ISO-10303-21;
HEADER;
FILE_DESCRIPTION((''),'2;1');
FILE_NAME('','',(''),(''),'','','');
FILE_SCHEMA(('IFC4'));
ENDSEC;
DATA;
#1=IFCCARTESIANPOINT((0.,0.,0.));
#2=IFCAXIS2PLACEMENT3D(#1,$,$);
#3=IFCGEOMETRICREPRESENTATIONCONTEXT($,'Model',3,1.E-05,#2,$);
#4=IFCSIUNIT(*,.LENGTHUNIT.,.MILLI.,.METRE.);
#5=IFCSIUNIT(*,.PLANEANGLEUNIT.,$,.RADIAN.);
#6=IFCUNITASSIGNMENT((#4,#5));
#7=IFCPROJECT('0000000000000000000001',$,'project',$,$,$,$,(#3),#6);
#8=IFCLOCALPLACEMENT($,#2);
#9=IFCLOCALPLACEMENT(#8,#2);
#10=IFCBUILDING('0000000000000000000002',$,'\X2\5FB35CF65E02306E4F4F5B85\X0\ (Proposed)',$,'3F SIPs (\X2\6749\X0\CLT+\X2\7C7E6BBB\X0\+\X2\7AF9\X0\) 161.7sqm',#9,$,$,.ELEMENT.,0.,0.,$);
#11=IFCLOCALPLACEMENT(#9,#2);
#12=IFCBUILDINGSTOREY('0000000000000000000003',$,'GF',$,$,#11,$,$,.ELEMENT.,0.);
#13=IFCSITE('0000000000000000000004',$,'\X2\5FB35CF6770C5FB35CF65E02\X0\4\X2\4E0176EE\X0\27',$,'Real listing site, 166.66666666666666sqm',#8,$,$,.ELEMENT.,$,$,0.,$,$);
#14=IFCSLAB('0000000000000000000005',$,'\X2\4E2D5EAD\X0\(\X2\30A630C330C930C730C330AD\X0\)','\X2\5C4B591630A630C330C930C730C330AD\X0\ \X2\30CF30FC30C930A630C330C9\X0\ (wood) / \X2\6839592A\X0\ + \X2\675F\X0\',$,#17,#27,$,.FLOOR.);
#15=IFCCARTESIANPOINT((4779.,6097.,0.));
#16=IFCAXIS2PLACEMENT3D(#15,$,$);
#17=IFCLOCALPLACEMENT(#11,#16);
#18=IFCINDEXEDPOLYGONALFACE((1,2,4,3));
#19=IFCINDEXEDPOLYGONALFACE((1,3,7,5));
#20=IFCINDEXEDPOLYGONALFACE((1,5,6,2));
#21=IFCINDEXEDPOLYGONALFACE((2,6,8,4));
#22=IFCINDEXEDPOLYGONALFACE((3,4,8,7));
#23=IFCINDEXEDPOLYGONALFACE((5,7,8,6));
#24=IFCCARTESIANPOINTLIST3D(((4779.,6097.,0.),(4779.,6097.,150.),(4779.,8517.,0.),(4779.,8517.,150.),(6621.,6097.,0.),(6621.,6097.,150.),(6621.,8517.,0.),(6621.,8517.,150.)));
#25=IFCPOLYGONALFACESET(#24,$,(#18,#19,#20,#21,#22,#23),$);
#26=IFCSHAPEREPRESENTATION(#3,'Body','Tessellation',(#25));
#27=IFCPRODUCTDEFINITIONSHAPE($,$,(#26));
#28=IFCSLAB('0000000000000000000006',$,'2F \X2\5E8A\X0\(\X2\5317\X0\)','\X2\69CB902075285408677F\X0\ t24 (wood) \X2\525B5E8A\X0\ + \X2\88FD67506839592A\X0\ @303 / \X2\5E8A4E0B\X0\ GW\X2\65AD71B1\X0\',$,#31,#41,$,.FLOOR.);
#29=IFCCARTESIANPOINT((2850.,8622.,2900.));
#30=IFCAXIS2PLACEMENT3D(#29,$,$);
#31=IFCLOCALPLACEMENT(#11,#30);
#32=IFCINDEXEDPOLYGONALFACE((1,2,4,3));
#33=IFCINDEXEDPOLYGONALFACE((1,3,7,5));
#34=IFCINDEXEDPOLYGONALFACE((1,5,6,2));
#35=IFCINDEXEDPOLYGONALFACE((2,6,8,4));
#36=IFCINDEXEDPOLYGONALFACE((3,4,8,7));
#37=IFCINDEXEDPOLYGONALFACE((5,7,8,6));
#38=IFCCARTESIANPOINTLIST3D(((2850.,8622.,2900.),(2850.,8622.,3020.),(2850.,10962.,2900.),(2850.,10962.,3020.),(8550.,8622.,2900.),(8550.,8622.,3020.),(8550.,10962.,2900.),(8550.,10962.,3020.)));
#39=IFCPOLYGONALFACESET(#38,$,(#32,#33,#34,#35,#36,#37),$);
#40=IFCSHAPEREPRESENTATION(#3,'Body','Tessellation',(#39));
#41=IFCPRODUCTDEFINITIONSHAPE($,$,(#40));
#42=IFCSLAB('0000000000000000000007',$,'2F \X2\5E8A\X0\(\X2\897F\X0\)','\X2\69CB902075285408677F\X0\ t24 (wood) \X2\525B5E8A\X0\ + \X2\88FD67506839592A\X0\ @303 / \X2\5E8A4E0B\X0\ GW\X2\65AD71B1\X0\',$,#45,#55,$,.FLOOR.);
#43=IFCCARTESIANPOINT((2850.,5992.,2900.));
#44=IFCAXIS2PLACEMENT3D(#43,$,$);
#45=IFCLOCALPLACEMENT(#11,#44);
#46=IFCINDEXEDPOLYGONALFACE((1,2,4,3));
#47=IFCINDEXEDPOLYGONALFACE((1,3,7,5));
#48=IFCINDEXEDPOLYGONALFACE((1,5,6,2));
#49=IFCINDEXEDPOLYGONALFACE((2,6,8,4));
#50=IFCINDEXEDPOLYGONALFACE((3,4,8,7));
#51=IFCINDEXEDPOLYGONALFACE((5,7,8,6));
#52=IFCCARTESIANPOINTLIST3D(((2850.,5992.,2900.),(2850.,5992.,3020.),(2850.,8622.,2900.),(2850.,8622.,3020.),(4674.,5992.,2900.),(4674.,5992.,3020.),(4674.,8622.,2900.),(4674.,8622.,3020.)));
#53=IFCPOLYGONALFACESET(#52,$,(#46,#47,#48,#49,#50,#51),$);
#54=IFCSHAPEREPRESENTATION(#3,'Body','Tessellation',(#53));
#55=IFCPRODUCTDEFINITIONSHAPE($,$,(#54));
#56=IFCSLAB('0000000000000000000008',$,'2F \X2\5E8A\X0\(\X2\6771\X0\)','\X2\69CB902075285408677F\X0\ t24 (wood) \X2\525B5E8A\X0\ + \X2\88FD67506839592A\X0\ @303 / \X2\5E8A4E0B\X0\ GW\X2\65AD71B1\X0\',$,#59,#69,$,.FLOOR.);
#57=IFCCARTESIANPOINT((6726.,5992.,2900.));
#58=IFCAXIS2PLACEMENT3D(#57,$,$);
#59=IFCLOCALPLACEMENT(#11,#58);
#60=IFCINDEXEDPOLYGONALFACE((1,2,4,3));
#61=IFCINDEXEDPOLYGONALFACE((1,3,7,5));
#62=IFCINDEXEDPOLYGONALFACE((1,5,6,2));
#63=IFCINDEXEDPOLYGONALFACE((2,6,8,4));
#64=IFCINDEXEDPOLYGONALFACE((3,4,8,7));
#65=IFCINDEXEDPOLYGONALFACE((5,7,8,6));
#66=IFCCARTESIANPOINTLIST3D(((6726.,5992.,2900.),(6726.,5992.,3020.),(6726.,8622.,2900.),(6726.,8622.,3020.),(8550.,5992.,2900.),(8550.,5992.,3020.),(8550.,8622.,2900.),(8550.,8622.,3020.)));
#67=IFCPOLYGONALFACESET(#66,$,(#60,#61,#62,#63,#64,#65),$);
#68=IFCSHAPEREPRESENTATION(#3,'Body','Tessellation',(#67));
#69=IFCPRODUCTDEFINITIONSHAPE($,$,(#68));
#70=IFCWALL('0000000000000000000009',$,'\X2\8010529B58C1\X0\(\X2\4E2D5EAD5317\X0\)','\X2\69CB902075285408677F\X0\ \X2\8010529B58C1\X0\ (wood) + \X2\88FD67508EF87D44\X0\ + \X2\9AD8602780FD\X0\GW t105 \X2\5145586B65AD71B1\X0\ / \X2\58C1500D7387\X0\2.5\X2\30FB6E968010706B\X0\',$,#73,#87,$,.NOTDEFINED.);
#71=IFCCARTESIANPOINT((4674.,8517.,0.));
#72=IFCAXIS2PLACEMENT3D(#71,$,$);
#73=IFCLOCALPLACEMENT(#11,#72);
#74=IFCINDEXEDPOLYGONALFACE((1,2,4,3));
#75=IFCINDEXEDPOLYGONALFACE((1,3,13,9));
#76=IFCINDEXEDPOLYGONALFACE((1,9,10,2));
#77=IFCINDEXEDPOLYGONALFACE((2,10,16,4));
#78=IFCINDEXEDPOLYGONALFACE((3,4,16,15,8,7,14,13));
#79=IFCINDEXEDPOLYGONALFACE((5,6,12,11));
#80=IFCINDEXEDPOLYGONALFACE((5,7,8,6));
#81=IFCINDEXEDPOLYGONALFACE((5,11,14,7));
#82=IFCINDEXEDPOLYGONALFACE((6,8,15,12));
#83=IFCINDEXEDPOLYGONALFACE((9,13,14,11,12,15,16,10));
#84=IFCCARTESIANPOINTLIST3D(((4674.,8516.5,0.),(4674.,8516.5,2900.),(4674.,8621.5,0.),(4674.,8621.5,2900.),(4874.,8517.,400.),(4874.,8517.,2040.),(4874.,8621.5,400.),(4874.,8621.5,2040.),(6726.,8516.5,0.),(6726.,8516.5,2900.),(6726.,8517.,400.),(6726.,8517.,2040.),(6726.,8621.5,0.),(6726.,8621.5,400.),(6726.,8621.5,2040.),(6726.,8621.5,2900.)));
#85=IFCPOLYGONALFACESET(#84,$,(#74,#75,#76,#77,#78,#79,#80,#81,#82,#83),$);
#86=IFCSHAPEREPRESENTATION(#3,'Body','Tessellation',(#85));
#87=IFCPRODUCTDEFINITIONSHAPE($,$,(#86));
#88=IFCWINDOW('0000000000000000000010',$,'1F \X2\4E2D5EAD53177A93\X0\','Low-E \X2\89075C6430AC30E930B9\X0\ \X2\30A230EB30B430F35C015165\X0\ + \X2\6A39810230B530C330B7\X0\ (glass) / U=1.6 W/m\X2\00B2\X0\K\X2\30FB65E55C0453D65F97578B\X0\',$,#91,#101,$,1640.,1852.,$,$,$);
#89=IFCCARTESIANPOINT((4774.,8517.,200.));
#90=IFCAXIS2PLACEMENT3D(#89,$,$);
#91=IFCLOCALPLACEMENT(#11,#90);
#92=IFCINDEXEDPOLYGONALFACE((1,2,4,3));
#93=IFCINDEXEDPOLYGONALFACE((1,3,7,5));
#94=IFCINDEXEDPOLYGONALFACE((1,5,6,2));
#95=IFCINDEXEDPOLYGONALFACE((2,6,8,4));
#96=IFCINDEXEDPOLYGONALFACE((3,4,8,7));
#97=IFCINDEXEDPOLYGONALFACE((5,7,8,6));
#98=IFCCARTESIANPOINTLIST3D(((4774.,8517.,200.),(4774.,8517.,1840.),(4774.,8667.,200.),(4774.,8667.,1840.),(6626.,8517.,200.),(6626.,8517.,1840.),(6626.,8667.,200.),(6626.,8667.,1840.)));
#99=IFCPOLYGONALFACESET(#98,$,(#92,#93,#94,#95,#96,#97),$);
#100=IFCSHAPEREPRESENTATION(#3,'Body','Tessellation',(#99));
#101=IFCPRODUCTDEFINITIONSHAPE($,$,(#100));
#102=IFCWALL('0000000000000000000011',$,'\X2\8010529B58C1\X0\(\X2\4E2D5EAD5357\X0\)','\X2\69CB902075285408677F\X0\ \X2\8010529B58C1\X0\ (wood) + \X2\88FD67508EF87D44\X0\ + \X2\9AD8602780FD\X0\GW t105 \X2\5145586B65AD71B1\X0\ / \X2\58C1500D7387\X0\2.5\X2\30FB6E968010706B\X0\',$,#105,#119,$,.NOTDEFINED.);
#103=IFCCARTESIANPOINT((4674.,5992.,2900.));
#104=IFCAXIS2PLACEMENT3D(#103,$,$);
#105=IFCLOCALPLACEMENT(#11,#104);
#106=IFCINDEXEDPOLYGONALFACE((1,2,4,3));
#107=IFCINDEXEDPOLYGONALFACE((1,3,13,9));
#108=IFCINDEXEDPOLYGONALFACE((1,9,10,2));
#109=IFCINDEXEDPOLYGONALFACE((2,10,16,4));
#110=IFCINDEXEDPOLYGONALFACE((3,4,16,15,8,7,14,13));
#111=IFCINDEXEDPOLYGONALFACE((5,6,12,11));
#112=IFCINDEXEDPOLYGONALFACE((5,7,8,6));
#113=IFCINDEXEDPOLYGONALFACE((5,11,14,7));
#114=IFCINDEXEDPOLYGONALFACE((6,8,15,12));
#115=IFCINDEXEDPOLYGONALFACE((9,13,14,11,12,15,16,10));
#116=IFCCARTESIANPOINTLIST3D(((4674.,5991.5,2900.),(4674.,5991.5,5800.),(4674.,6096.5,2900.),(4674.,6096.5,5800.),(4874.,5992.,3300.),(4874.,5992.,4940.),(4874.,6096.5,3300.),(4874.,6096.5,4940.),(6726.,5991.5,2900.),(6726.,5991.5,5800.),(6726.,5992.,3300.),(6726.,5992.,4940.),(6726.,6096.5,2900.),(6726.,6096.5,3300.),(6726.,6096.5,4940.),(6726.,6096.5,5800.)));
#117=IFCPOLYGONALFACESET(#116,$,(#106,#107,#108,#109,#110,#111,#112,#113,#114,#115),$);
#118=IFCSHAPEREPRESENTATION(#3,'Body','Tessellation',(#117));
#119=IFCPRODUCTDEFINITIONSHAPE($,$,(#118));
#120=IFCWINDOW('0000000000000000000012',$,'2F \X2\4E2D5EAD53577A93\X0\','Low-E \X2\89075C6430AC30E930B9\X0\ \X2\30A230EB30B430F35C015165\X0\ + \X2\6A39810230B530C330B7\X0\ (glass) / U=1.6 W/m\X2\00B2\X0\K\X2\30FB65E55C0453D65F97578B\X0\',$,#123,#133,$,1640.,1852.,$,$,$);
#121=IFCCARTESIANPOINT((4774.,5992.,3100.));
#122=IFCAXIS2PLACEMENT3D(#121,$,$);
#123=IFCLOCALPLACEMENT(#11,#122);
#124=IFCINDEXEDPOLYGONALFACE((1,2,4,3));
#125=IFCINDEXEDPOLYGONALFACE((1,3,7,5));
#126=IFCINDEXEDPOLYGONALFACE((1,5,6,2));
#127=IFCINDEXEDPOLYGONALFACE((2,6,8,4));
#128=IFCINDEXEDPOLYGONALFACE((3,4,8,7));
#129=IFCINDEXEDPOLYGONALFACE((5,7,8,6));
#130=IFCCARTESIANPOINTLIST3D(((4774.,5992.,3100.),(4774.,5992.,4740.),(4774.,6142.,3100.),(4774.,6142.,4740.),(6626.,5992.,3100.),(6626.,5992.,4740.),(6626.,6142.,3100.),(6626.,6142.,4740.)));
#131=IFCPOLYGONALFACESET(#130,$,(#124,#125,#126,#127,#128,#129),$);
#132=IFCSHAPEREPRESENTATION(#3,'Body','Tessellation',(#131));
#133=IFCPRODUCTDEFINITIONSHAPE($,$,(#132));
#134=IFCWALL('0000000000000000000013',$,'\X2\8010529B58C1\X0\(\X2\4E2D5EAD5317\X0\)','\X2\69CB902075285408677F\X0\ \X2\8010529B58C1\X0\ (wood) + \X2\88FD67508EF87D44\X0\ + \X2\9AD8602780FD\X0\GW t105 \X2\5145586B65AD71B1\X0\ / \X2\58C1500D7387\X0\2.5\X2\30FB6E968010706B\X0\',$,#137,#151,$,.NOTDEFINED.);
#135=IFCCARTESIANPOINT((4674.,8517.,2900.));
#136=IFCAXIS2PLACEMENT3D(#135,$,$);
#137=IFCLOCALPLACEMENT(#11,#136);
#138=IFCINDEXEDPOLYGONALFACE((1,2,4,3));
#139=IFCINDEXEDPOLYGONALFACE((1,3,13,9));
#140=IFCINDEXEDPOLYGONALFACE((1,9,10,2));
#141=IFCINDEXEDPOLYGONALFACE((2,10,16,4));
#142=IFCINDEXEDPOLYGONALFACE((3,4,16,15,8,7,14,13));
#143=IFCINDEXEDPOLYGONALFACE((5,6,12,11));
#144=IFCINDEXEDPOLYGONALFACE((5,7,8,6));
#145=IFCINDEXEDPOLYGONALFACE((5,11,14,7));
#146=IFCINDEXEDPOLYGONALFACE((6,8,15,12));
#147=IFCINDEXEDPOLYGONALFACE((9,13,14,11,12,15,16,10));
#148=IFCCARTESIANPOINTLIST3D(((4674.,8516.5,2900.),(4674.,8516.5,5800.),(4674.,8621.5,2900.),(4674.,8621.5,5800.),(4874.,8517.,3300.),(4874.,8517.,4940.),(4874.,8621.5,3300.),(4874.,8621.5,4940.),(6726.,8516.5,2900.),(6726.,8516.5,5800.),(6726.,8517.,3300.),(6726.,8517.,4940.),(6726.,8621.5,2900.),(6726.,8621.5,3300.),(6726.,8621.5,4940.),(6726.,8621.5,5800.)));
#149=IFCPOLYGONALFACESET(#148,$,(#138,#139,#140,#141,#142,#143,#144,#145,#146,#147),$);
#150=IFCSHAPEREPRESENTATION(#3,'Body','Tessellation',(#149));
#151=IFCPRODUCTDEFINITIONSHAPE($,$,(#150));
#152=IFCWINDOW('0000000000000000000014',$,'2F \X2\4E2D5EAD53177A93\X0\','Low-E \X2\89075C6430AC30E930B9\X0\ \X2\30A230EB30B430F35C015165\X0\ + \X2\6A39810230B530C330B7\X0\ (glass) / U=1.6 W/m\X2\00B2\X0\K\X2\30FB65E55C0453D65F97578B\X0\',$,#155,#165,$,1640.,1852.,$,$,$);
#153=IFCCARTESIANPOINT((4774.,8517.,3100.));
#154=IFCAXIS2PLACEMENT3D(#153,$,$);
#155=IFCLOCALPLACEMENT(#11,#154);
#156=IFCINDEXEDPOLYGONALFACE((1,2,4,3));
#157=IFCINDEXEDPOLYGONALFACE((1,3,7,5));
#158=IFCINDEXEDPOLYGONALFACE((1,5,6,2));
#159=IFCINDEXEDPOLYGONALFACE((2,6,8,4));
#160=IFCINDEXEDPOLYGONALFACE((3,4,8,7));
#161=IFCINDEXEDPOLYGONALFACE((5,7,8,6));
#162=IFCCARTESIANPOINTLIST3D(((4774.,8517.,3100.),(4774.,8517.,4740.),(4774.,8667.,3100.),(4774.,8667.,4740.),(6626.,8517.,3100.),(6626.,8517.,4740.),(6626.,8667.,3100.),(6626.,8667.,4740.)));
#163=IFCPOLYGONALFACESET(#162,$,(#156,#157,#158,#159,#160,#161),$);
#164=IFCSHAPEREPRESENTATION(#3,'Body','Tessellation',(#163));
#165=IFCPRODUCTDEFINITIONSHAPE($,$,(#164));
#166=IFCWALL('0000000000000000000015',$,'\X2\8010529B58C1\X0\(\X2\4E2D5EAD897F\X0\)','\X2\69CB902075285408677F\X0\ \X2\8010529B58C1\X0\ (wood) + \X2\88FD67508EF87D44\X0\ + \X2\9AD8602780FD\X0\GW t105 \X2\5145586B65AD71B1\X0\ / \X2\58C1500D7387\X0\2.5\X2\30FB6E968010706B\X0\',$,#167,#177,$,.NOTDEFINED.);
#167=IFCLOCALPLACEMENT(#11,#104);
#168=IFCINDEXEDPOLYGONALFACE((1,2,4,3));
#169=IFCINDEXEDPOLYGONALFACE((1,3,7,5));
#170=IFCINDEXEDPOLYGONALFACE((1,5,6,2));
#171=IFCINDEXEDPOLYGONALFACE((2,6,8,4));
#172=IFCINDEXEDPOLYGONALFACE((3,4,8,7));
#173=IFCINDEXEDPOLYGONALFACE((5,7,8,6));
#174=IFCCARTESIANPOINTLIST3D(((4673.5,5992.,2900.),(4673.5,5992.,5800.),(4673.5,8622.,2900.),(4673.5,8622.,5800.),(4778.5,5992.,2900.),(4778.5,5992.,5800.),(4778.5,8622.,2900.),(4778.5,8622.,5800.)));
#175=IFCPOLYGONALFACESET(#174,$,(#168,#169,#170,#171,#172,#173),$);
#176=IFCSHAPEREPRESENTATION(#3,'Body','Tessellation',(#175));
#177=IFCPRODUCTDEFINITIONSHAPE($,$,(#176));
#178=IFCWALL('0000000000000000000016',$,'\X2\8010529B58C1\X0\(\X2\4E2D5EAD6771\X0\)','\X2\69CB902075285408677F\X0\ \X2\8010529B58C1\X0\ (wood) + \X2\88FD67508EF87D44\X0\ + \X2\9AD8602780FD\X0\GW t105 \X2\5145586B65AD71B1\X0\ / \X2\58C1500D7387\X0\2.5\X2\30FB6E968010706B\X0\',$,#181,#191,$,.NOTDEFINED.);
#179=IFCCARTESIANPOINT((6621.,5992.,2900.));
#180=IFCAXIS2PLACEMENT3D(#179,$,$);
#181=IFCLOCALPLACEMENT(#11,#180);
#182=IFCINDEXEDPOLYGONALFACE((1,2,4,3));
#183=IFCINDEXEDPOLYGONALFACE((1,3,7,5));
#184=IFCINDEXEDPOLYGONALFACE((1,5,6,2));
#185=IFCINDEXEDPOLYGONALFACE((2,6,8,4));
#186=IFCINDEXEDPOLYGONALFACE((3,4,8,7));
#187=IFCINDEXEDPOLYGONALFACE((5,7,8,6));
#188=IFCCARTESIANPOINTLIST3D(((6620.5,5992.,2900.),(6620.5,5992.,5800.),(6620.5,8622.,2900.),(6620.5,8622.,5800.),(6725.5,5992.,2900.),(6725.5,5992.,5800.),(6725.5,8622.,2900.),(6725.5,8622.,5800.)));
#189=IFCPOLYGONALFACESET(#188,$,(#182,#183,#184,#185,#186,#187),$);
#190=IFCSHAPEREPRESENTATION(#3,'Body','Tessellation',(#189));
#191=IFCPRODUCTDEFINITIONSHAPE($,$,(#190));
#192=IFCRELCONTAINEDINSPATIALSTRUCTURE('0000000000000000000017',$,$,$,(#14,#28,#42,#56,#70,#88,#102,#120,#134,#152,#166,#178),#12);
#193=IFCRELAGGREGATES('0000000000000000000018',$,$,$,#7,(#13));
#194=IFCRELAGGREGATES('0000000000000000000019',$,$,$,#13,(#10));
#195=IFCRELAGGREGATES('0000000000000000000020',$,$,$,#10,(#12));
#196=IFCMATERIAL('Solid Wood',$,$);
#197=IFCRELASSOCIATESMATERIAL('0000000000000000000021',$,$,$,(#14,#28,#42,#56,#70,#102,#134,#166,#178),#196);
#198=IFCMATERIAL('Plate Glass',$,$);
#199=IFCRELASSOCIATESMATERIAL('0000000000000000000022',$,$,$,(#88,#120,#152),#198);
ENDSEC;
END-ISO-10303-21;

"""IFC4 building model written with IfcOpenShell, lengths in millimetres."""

from ifc_helpers import new_model, si_unit, frame, frame_2d, origin, place, context, project, spatial, rectangle, extrude, material, element, fill, save


model = new_model("IFC4")

# Units and contexts
model_context = context("Model", 3, precision=1e-05, world=origin())
ifc_project = project(units=[si_unit("LENGTHUNIT", "METRE", prefix="MILLI"), si_unit("PLANEANGLEUNIT", "RADIAN")], contexts=[model_context])

# Site, building, storey
site_placement = place(None, origin())
site = spatial("IfcSite", under=ifc_project, at=site_placement, Name="徳島県徳島市4丁目27", ObjectType="Real listing site, 166.66666666666666sqm", CompositionType="ELEMENT", RefElevation=0.0)
building_placement = place(site_placement, origin())
building = spatial("IfcBuilding", under=site, at=building_placement, Name="徳島市の住宅 (Proposed)", ObjectType="3F SIPs (杉CLT+籾殻+竹) 161.7sqm", CompositionType="ELEMENT", ElevationOfRefHeight=0.0, ElevationOfTerrain=0.0)
storey_placement = place(building_placement, origin())
storey = spatial("IfcBuildingStorey", under=building, at=storey_placement, Name="GF", CompositionType="ELEMENT", Elevation=0.0)

# Slabs
ifc_material_1 = material(Name="Solid Wood")
slab_1_placement = place(storey_placement, frame((4779.0, 6097.0, 0.0)))
element("IfcSlab", 1, at=slab_1_placement, inside=storey, material=ifc_material_1, Name="中庭(ウッドデッキ)", Description="屋外ウッドデッキ ハードウッド (wood) / 根太 + 束", PredefinedType="FLOOR", context=model_context, shape_type="SweptSolid", body=[
    extrude(rectangle(XDim=1842.0, YDim=2420.0, at=frame_2d((921.0, 1210.0))), frame((4779.0, 6097.0, 0.0)), (0.0, 0.0, 1.0), 150.0),
])
slab_2_placement = place(storey_placement, frame((2850.0, 8622.0, 2900.0)))
element("IfcSlab", 2, at=slab_2_placement, inside=storey, material=ifc_material_1, Name="2F 床(北)", Description="構造用合板 t24 (wood) 剛床 + 製材根太 @303 / 床下 GW断熱", PredefinedType="FLOOR", context=model_context, shape_type="SweptSolid", body=[
    extrude(rectangle(XDim=5700.0, YDim=2340.0, at=frame_2d((2850.0, 1170.0))), frame((2850.0, 8622.0, 2900.0)), (0.0, 0.0, 1.0), 120.0),
])
slab_3_placement = place(storey_placement, frame((2850.0, 5992.0, 2900.0)))
element("IfcSlab", 3, at=slab_3_placement, inside=storey, material=ifc_material_1, Name="2F 床(西)", Description="構造用合板 t24 (wood) 剛床 + 製材根太 @303 / 床下 GW断熱", PredefinedType="FLOOR", context=model_context, shape_type="SweptSolid", body=[
    extrude(rectangle(XDim=1824.0, YDim=2630.0, at=frame_2d((912.0, 1315.0))), frame((2850.0, 5992.0, 2900.0)), (0.0, 0.0, 1.0), 120.0),
])
slab_4_placement = place(storey_placement, frame((6726.0, 5992.0, 2900.0)))
element("IfcSlab", 4, at=slab_4_placement, inside=storey, material=ifc_material_1, Name="2F 床(東)", Description="構造用合板 t24 (wood) 剛床 + 製材根太 @303 / 床下 GW断熱", PredefinedType="FLOOR", context=model_context, shape_type="SweptSolid", body=[
    extrude(rectangle(XDim=1824.0, YDim=2630.0, at=frame_2d((912.0, 1315.0))), frame((6726.0, 5992.0, 2900.0)), (0.0, 0.0, 1.0), 120.0),
])

# Wall, opening, window
wall_1_placement = place(storey_placement, frame((4674.0, 8517.0, 0.0)))
wall_1 = element("IfcWall", 5, at=wall_1_placement, inside=storey, material=ifc_material_1, Name="耐力壁(中庭北)", Description="構造用合板 耐力壁 (wood) + 製材軸組 + 高性能GW t105 充填断熱 / 壁倍率2.5・準耐火", PredefinedType="NOTDEFINED", context=model_context, shape_type="SweptSolid", body=[
    extrude(rectangle(XDim=2052.0, YDim=105.0, at=frame_2d((1026.0, 52.0))), frame((4674.0, 8517.0, 0.0)), (0.0, 0.0, 1.0), 2900.0),
])
opening_1_placement = place(storey_placement, frame((4774.0, 8517.0, 200.0)))
opening_1 = element("IfcOpeningElement", 6, at=opening_1_placement, cuts=wall_1, PredefinedType="NOTDEFINED", context=model_context, shape_type="SweptSolid", body=[
    extrude(rectangle(XDim=1852.0, YDim=150.0, at=frame_2d((926.0, 75.0))), frame((4774.0, 8517.0, 200.0)), (0.0, 0.0, 1.0), 1640.0),
])
ifc_material_2 = material(Name="Plate Glass")
window_1_placement = place(storey_placement, frame((4774.0, 8517.0, 200.0)))
window_1 = element("IfcWindow", 7, at=window_1_placement, inside=storey, material=ifc_material_2, Name="1F 中庭北窓", Description="Low-E 複層ガラス アルゴン封入 + 樹脂サッシ (glass) / U=1.6 W/m²K・日射取得型", OverallHeight=1640.0, OverallWidth=1852.0, context=model_context, shape_type="SweptSolid", body=[
    extrude(rectangle(XDim=1852.0, YDim=150.0, at=frame_2d((926.0, 75.0))), frame((4774.0, 8517.0, 200.0)), (0.0, 0.0, 1.0), 1640.0),
])
fill(opening_1, window_1)

# Walls, openings, windows
wall_2_placement = place(storey_placement, frame((4674.0, 5992.0, 2900.0)))
wall_2 = element("IfcWall", 8, at=wall_2_placement, inside=storey, material=ifc_material_1, Name="耐力壁(中庭南)", Description="構造用合板 耐力壁 (wood) + 製材軸組 + 高性能GW t105 充填断熱 / 壁倍率2.5・準耐火", PredefinedType="NOTDEFINED", context=model_context, shape_type="SweptSolid", body=[
    extrude(rectangle(XDim=2052.0, YDim=105.0, at=frame_2d((1026.0, 52.0))), frame((4674.0, 5992.0, 2900.0)), (0.0, 0.0, 1.0), 2900.0),
])
opening_2_placement = place(storey_placement, frame((4774.0, 5992.0, 3100.0)))
opening_2 = element("IfcOpeningElement", 9, at=opening_2_placement, cuts=wall_2, PredefinedType="NOTDEFINED", context=model_context, shape_type="SweptSolid", body=[
    extrude(rectangle(XDim=1852.0, YDim=150.0, at=frame_2d((926.0, 75.0))), frame((4774.0, 5992.0, 3100.0)), (0.0, 0.0, 1.0), 1640.0),
])
window_2_placement = place(storey_placement, frame((4774.0, 5992.0, 3100.0)))
window_2 = element("IfcWindow", 10, at=window_2_placement, inside=storey, material=ifc_material_2, Name="2F 中庭南窓", Description="Low-E 複層ガラス アルゴン封入 + 樹脂サッシ (glass) / U=1.6 W/m²K・日射取得型", OverallHeight=1640.0, OverallWidth=1852.0, context=model_context, shape_type="SweptSolid", body=[
    extrude(rectangle(XDim=1852.0, YDim=150.0, at=frame_2d((926.0, 75.0))), frame((4774.0, 5992.0, 3100.0)), (0.0, 0.0, 1.0), 1640.0),
])
fill(opening_2, window_2)
wall_3_placement = place(storey_placement, frame((4674.0, 8517.0, 2900.0)))
wall_3 = element("IfcWall", 11, at=wall_3_placement, inside=storey, material=ifc_material_1, Name="耐力壁(中庭北)", Description="構造用合板 耐力壁 (wood) + 製材軸組 + 高性能GW t105 充填断熱 / 壁倍率2.5・準耐火", PredefinedType="NOTDEFINED", context=model_context, shape_type="SweptSolid", body=[
    extrude(rectangle(XDim=2052.0, YDim=105.0, at=frame_2d((1026.0, 52.0))), frame((4674.0, 8517.0, 2900.0)), (0.0, 0.0, 1.0), 2900.0),
])
opening_3_placement = place(storey_placement, frame((4774.0, 8517.0, 3100.0)))
opening_3 = element("IfcOpeningElement", 12, at=opening_3_placement, cuts=wall_3, PredefinedType="NOTDEFINED", context=model_context, shape_type="SweptSolid", body=[
    extrude(rectangle(XDim=1852.0, YDim=150.0, at=frame_2d((926.0, 75.0))), frame((4774.0, 8517.0, 3100.0)), (0.0, 0.0, 1.0), 1640.0),
])
window_3_placement = place(storey_placement, frame((4774.0, 8517.0, 3100.0)))
window_3 = element("IfcWindow", 13, at=window_3_placement, inside=storey, material=ifc_material_2, Name="2F 中庭北窓", Description="Low-E 複層ガラス アルゴン封入 + 樹脂サッシ (glass) / U=1.6 W/m²K・日射取得型", OverallHeight=1640.0, OverallWidth=1852.0, context=model_context, shape_type="SweptSolid", body=[
    extrude(rectangle(XDim=1852.0, YDim=150.0, at=frame_2d((926.0, 75.0))), frame((4774.0, 8517.0, 3100.0)), (0.0, 0.0, 1.0), 1640.0),
])
fill(opening_3, window_3)

# Walls
wall_4_placement = place(storey_placement, frame((4674.0, 5992.0, 2900.0)))
element("IfcWall", 14, at=wall_4_placement, inside=storey, material=ifc_material_1, Name="耐力壁(中庭西)", Description="構造用合板 耐力壁 (wood) + 製材軸組 + 高性能GW t105 充填断熱 / 壁倍率2.5・準耐火", PredefinedType="NOTDEFINED", context=model_context, shape_type="SweptSolid", body=[
    extrude(rectangle(XDim=105.0, YDim=2630.0, at=frame_2d((52.0, 1315.0))), frame((4674.0, 5992.0, 2900.0)), (0.0, 0.0, 1.0), 2900.0),
])
wall_5_placement = place(storey_placement, frame((6621.0, 5992.0, 2900.0)))
element("IfcWall", 15, at=wall_5_placement, inside=storey, material=ifc_material_1, Name="耐力壁(中庭東)", Description="構造用合板 耐力壁 (wood) + 製材軸組 + 高性能GW t105 充填断熱 / 壁倍率2.5・準耐火", PredefinedType="NOTDEFINED", context=model_context, shape_type="SweptSolid", body=[
    extrude(rectangle(XDim=105.0, YDim=2630.0, at=frame_2d((52.0, 1315.0))), frame((6621.0, 5992.0, 2900.0)), (0.0, 0.0, 1.0), 2900.0),
])

save(model, "model.ifc")
